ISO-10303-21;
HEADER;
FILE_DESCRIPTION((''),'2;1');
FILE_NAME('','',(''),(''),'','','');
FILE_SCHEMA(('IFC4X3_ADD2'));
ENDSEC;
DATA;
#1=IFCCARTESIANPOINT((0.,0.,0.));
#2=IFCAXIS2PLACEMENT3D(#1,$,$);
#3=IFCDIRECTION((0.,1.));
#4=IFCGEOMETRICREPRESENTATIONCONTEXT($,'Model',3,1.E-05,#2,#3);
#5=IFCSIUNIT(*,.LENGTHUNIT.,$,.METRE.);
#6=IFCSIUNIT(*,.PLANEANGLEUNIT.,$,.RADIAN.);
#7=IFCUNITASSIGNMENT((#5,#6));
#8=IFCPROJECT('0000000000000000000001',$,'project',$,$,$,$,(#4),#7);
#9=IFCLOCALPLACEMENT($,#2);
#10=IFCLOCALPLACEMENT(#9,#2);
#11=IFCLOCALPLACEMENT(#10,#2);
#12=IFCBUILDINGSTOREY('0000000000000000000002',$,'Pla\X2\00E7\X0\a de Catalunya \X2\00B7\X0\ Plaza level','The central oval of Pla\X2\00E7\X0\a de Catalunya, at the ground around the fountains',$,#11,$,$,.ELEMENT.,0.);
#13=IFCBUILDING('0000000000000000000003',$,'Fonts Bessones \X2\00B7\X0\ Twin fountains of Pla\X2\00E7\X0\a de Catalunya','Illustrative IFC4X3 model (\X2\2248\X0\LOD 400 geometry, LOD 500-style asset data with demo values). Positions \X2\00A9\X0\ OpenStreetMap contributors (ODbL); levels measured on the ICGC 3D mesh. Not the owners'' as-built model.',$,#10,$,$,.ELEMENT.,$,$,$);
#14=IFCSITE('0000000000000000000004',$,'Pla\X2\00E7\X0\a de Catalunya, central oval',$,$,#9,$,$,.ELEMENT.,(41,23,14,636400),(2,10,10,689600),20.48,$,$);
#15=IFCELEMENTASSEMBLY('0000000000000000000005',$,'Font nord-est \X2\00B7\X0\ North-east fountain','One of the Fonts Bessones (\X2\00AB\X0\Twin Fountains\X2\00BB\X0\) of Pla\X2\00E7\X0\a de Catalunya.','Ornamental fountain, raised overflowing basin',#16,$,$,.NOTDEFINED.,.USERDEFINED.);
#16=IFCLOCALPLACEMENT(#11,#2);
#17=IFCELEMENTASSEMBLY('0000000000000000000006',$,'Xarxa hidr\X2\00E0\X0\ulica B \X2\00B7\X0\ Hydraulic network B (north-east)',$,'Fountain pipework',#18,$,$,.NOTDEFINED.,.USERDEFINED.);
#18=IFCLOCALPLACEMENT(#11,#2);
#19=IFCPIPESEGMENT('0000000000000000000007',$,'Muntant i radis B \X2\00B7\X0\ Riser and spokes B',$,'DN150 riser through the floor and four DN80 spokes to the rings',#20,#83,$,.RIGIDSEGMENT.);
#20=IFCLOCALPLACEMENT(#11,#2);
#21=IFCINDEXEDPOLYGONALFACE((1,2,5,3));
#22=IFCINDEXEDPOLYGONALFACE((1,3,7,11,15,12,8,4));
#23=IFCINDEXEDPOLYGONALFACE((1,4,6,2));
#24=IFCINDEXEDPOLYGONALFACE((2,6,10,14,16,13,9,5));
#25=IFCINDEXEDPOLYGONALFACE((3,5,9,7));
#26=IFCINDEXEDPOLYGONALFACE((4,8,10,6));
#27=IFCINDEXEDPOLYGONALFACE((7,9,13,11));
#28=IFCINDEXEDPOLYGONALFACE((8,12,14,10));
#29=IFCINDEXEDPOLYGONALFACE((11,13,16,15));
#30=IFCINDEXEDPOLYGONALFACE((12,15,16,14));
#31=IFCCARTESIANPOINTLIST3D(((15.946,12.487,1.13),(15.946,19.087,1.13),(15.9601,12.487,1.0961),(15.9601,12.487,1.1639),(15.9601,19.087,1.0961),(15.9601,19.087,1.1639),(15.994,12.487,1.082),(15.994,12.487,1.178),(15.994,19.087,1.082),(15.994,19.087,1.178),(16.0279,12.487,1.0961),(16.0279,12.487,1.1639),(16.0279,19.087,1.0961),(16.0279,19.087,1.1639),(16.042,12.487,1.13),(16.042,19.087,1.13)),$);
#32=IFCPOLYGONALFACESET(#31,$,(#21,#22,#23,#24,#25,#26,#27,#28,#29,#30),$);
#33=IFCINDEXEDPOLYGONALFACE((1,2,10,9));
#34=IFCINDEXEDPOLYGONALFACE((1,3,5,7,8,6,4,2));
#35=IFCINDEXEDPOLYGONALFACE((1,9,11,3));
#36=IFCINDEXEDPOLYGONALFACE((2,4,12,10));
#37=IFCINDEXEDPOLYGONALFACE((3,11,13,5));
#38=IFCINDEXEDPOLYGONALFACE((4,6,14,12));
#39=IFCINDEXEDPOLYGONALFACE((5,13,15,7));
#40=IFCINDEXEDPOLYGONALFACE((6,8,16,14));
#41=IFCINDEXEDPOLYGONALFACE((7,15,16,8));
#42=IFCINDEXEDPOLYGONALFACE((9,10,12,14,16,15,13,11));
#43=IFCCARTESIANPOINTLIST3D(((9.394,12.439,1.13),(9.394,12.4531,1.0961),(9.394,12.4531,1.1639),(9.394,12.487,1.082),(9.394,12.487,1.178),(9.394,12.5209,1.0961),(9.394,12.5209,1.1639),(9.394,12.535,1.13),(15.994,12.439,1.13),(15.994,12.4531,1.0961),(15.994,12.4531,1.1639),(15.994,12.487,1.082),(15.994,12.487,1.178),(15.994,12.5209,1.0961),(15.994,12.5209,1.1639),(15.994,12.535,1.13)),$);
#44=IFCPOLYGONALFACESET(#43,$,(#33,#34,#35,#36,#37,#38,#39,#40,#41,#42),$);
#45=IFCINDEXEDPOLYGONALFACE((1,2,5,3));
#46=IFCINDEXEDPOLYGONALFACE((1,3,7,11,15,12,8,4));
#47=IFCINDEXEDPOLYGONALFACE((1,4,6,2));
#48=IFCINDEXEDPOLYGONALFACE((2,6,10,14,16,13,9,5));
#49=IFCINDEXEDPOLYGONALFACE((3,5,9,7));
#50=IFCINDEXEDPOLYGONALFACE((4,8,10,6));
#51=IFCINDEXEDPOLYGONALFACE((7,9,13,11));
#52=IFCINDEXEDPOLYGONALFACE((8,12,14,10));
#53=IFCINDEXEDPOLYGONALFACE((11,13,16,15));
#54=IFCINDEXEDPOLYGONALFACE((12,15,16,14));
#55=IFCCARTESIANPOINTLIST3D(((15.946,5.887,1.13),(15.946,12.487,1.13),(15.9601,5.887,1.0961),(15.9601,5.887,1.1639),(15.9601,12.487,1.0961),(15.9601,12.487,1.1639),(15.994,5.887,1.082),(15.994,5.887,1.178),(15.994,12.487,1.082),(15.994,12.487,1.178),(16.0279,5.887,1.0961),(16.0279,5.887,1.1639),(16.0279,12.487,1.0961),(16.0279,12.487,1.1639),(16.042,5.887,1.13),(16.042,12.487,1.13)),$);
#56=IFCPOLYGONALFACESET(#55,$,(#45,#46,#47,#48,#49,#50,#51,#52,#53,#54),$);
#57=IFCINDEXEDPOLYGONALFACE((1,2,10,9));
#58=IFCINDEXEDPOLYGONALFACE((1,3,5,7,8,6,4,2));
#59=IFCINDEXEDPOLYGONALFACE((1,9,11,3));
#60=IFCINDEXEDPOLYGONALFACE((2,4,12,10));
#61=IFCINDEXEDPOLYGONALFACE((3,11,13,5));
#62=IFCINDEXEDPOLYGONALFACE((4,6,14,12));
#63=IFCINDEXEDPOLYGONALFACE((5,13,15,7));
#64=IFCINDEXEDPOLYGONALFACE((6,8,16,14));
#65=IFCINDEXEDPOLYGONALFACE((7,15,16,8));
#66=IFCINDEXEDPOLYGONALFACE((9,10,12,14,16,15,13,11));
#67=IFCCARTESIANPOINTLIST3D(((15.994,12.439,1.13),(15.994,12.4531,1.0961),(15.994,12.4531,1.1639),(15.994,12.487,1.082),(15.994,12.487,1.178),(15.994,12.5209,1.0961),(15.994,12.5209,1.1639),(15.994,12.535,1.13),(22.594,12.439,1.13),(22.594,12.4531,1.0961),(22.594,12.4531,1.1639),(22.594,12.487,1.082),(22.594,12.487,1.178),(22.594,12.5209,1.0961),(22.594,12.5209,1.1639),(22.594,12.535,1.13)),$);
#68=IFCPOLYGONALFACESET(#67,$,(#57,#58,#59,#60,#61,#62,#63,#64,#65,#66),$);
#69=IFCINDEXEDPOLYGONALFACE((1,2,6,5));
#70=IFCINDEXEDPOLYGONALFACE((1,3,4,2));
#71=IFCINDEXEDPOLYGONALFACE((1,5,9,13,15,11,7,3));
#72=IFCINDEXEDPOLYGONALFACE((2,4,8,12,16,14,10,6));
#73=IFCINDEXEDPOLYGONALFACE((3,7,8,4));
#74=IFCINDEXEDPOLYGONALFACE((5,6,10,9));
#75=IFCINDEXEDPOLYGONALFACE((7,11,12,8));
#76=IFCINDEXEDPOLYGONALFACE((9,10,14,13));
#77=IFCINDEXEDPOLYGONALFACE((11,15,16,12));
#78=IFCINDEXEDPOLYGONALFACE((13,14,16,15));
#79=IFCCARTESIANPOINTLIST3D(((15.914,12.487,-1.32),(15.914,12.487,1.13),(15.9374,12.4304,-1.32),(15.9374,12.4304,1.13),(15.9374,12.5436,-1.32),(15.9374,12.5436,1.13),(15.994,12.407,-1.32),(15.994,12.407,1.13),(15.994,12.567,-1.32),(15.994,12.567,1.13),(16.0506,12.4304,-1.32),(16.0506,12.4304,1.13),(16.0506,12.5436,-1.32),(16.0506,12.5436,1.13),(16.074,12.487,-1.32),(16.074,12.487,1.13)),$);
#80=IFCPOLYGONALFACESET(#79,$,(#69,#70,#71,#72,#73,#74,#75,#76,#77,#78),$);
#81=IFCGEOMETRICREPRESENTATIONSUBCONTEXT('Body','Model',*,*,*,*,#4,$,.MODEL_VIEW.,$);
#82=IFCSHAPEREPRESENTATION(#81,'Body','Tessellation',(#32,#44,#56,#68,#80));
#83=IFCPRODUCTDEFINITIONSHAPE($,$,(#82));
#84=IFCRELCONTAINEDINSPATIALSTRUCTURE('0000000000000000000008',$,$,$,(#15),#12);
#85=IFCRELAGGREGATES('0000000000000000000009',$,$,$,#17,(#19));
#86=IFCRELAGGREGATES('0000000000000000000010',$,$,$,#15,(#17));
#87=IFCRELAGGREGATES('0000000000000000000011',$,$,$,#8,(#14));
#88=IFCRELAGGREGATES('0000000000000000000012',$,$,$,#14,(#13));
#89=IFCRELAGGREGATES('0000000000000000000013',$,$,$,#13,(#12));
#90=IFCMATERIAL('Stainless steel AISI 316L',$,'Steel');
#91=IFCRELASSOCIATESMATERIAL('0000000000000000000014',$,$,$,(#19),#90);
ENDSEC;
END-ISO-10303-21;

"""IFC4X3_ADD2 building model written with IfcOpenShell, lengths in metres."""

from ifc_helpers import new_model, si_unit, direction, frame, origin, place, context, subcontext, project, spatial, polyline, outline, extrude, material, element, aggregate, save


model = new_model("IFC4X3_ADD2")

# Units and contexts
model_context = context("Model", 3, precision=1e-05, world=origin(), true_north=direction((0.0, 1.0)))
body_context = subcontext(model_context, "Body", "Model", "MODEL_VIEW")
ifc_project = project(units=[si_unit("LENGTHUNIT", "METRE"), si_unit("PLANEANGLEUNIT", "RADIAN")], contexts=[model_context])

# Site, building, storey
site_placement = place(None, origin())
site = spatial("IfcSite", under=ifc_project, at=site_placement, Name="Plaça de Catalunya, central oval", CompositionType="ELEMENT", RefLatitude=(41, 23, 14, 636400), RefLongitude=(2, 10, 10, 689600), RefElevation=20.48)
building_placement = place(site_placement, origin())
building = spatial("IfcBuilding", under=site, at=building_placement, Name="Fonts Bessones · Twin fountains of Plaça de Catalunya", Description="Illustrative IFC4X3 model (≈LOD 400 geometry, LOD 500-style asset data with demo values). Positions © OpenStreetMap contributors (ODbL); levels measured on the ICGC 3D mesh. Not the owners' as-built model.", CompositionType="ELEMENT")
storey_placement = place(building_placement, origin())
storey = spatial("IfcBuildingStorey", under=building, at=storey_placement, Name="Plaça de Catalunya · Plaza level", Description="The central oval of Plaça de Catalunya, at the ground around the fountains", CompositionType="ELEMENT", Elevation=0.0)

# Element assemblies, pipe segment
assembly_1_placement = place(building_placement, origin())
assembly_1 = element("IfcElementAssembly", 1, at=assembly_1_placement, inside=storey, Name="Font nord-est · North-east fountain", Description="One of the Fonts Bessones («Twin Fountains») of Plaça de Catalunya.", ObjectType="Ornamental fountain, raised overflowing basin", AssemblyPlace="NOTDEFINED", PredefinedType="USERDEFINED")
ifc_material_1 = material(Name="Stainless steel AISI 316L", Category="Steel")
assembly_2_placement = place(building_placement, origin())
assembly_2 = element("IfcElementAssembly", 2, at=assembly_2_placement, Name="Xarxa hidràulica B · Hydraulic network B (north-east)", ObjectType="Fountain pipework", AssemblyPlace="NOTDEFINED", PredefinedType="USERDEFINED")
pipe_segment_1_placement = place(building_placement, origin())
pipe_segment_1 = element("IfcPipeSegment", 3, at=pipe_segment_1_placement, material=ifc_material_1, Name="Muntant i radis B · Riser and spokes B", ObjectType="DN150 riser through the floor and four DN80 spokes to the rings", PredefinedType="RIGIDSEGMENT", context=body_context, shape_type="SweptSolid", body=[
    extrude(outline(polyline([(0.048, 0.0), (0.0339, 0.0339), (0.0, 0.048), (-0.0339, 0.0339), (-0.048, 0.0), (-0.0339, -0.0339), (0.0, -0.048), (0.0339, -0.0339), (0.048, 0.0)])), frame((15.994, 12.487, 1.13), z_axis=(0.0, 1.0, 0.0), x_axis=(1.0, 0.0, 0.0)), (0.0, 0.0, 1.0), 6.6),
    extrude(outline(polyline([(0.048, 0.0), (0.0339, 0.0339), (0.0, 0.048), (-0.0339, 0.0339), (-0.048, 0.0), (-0.0339, -0.0339), (0.0, -0.048), (0.0339, -0.0339), (0.048, 0.0)])), frame((15.994, 12.487, 1.13), z_axis=(-1.0, 0.0, 0.0), x_axis=(0.0, 1.0, 0.0)), (0.0, 0.0, 1.0), 6.6),
    extrude(outline(polyline([(0.048, 0.0), (0.0339, 0.0339), (0.0, 0.048), (-0.0339, 0.0339), (-0.048, 0.0), (-0.0339, -0.0339), (0.0, -0.048), (0.0339, -0.0339), (0.048, 0.0)])), frame((15.994, 12.487, 1.13), z_axis=(0.0, -1.0, 0.0), x_axis=(-1.0, 0.0, 0.0)), (0.0, 0.0, 1.0), 6.6),
    extrude(outline(polyline([(0.048, 0.0), (0.0339, 0.0339), (0.0, 0.048), (-0.0339, 0.0339), (-0.048, 0.0), (-0.0339, -0.0339), (0.0, -0.048), (0.0339, -0.0339), (0.048, 0.0)])), frame((15.994, 12.487, 1.13), z_axis=(1.0, 0.0, 0.0), x_axis=(0.0, -1.0, 0.0)), (0.0, 0.0, 1.0), 6.6),
    extrude(outline(polyline([(0.08, 0.0), (0.0566, 0.0566), (0.0, 0.08), (-0.0566, 0.0566), (-0.08, 0.0), (-0.0566, -0.0566), (0.0, -0.08), (0.0566, -0.0566), (0.08, 0.0)])), frame((15.994, 12.487, -1.32), z_axis=(0.0, 0.0, 1.0), x_axis=(0.0, 1.0, 0.0)), (0.0, 0.0, 1.0), 2.45),
])
aggregate(assembly_2, [pipe_segment_1])
aggregate(assembly_1, [assembly_2])

save(model, "model.ifc")
